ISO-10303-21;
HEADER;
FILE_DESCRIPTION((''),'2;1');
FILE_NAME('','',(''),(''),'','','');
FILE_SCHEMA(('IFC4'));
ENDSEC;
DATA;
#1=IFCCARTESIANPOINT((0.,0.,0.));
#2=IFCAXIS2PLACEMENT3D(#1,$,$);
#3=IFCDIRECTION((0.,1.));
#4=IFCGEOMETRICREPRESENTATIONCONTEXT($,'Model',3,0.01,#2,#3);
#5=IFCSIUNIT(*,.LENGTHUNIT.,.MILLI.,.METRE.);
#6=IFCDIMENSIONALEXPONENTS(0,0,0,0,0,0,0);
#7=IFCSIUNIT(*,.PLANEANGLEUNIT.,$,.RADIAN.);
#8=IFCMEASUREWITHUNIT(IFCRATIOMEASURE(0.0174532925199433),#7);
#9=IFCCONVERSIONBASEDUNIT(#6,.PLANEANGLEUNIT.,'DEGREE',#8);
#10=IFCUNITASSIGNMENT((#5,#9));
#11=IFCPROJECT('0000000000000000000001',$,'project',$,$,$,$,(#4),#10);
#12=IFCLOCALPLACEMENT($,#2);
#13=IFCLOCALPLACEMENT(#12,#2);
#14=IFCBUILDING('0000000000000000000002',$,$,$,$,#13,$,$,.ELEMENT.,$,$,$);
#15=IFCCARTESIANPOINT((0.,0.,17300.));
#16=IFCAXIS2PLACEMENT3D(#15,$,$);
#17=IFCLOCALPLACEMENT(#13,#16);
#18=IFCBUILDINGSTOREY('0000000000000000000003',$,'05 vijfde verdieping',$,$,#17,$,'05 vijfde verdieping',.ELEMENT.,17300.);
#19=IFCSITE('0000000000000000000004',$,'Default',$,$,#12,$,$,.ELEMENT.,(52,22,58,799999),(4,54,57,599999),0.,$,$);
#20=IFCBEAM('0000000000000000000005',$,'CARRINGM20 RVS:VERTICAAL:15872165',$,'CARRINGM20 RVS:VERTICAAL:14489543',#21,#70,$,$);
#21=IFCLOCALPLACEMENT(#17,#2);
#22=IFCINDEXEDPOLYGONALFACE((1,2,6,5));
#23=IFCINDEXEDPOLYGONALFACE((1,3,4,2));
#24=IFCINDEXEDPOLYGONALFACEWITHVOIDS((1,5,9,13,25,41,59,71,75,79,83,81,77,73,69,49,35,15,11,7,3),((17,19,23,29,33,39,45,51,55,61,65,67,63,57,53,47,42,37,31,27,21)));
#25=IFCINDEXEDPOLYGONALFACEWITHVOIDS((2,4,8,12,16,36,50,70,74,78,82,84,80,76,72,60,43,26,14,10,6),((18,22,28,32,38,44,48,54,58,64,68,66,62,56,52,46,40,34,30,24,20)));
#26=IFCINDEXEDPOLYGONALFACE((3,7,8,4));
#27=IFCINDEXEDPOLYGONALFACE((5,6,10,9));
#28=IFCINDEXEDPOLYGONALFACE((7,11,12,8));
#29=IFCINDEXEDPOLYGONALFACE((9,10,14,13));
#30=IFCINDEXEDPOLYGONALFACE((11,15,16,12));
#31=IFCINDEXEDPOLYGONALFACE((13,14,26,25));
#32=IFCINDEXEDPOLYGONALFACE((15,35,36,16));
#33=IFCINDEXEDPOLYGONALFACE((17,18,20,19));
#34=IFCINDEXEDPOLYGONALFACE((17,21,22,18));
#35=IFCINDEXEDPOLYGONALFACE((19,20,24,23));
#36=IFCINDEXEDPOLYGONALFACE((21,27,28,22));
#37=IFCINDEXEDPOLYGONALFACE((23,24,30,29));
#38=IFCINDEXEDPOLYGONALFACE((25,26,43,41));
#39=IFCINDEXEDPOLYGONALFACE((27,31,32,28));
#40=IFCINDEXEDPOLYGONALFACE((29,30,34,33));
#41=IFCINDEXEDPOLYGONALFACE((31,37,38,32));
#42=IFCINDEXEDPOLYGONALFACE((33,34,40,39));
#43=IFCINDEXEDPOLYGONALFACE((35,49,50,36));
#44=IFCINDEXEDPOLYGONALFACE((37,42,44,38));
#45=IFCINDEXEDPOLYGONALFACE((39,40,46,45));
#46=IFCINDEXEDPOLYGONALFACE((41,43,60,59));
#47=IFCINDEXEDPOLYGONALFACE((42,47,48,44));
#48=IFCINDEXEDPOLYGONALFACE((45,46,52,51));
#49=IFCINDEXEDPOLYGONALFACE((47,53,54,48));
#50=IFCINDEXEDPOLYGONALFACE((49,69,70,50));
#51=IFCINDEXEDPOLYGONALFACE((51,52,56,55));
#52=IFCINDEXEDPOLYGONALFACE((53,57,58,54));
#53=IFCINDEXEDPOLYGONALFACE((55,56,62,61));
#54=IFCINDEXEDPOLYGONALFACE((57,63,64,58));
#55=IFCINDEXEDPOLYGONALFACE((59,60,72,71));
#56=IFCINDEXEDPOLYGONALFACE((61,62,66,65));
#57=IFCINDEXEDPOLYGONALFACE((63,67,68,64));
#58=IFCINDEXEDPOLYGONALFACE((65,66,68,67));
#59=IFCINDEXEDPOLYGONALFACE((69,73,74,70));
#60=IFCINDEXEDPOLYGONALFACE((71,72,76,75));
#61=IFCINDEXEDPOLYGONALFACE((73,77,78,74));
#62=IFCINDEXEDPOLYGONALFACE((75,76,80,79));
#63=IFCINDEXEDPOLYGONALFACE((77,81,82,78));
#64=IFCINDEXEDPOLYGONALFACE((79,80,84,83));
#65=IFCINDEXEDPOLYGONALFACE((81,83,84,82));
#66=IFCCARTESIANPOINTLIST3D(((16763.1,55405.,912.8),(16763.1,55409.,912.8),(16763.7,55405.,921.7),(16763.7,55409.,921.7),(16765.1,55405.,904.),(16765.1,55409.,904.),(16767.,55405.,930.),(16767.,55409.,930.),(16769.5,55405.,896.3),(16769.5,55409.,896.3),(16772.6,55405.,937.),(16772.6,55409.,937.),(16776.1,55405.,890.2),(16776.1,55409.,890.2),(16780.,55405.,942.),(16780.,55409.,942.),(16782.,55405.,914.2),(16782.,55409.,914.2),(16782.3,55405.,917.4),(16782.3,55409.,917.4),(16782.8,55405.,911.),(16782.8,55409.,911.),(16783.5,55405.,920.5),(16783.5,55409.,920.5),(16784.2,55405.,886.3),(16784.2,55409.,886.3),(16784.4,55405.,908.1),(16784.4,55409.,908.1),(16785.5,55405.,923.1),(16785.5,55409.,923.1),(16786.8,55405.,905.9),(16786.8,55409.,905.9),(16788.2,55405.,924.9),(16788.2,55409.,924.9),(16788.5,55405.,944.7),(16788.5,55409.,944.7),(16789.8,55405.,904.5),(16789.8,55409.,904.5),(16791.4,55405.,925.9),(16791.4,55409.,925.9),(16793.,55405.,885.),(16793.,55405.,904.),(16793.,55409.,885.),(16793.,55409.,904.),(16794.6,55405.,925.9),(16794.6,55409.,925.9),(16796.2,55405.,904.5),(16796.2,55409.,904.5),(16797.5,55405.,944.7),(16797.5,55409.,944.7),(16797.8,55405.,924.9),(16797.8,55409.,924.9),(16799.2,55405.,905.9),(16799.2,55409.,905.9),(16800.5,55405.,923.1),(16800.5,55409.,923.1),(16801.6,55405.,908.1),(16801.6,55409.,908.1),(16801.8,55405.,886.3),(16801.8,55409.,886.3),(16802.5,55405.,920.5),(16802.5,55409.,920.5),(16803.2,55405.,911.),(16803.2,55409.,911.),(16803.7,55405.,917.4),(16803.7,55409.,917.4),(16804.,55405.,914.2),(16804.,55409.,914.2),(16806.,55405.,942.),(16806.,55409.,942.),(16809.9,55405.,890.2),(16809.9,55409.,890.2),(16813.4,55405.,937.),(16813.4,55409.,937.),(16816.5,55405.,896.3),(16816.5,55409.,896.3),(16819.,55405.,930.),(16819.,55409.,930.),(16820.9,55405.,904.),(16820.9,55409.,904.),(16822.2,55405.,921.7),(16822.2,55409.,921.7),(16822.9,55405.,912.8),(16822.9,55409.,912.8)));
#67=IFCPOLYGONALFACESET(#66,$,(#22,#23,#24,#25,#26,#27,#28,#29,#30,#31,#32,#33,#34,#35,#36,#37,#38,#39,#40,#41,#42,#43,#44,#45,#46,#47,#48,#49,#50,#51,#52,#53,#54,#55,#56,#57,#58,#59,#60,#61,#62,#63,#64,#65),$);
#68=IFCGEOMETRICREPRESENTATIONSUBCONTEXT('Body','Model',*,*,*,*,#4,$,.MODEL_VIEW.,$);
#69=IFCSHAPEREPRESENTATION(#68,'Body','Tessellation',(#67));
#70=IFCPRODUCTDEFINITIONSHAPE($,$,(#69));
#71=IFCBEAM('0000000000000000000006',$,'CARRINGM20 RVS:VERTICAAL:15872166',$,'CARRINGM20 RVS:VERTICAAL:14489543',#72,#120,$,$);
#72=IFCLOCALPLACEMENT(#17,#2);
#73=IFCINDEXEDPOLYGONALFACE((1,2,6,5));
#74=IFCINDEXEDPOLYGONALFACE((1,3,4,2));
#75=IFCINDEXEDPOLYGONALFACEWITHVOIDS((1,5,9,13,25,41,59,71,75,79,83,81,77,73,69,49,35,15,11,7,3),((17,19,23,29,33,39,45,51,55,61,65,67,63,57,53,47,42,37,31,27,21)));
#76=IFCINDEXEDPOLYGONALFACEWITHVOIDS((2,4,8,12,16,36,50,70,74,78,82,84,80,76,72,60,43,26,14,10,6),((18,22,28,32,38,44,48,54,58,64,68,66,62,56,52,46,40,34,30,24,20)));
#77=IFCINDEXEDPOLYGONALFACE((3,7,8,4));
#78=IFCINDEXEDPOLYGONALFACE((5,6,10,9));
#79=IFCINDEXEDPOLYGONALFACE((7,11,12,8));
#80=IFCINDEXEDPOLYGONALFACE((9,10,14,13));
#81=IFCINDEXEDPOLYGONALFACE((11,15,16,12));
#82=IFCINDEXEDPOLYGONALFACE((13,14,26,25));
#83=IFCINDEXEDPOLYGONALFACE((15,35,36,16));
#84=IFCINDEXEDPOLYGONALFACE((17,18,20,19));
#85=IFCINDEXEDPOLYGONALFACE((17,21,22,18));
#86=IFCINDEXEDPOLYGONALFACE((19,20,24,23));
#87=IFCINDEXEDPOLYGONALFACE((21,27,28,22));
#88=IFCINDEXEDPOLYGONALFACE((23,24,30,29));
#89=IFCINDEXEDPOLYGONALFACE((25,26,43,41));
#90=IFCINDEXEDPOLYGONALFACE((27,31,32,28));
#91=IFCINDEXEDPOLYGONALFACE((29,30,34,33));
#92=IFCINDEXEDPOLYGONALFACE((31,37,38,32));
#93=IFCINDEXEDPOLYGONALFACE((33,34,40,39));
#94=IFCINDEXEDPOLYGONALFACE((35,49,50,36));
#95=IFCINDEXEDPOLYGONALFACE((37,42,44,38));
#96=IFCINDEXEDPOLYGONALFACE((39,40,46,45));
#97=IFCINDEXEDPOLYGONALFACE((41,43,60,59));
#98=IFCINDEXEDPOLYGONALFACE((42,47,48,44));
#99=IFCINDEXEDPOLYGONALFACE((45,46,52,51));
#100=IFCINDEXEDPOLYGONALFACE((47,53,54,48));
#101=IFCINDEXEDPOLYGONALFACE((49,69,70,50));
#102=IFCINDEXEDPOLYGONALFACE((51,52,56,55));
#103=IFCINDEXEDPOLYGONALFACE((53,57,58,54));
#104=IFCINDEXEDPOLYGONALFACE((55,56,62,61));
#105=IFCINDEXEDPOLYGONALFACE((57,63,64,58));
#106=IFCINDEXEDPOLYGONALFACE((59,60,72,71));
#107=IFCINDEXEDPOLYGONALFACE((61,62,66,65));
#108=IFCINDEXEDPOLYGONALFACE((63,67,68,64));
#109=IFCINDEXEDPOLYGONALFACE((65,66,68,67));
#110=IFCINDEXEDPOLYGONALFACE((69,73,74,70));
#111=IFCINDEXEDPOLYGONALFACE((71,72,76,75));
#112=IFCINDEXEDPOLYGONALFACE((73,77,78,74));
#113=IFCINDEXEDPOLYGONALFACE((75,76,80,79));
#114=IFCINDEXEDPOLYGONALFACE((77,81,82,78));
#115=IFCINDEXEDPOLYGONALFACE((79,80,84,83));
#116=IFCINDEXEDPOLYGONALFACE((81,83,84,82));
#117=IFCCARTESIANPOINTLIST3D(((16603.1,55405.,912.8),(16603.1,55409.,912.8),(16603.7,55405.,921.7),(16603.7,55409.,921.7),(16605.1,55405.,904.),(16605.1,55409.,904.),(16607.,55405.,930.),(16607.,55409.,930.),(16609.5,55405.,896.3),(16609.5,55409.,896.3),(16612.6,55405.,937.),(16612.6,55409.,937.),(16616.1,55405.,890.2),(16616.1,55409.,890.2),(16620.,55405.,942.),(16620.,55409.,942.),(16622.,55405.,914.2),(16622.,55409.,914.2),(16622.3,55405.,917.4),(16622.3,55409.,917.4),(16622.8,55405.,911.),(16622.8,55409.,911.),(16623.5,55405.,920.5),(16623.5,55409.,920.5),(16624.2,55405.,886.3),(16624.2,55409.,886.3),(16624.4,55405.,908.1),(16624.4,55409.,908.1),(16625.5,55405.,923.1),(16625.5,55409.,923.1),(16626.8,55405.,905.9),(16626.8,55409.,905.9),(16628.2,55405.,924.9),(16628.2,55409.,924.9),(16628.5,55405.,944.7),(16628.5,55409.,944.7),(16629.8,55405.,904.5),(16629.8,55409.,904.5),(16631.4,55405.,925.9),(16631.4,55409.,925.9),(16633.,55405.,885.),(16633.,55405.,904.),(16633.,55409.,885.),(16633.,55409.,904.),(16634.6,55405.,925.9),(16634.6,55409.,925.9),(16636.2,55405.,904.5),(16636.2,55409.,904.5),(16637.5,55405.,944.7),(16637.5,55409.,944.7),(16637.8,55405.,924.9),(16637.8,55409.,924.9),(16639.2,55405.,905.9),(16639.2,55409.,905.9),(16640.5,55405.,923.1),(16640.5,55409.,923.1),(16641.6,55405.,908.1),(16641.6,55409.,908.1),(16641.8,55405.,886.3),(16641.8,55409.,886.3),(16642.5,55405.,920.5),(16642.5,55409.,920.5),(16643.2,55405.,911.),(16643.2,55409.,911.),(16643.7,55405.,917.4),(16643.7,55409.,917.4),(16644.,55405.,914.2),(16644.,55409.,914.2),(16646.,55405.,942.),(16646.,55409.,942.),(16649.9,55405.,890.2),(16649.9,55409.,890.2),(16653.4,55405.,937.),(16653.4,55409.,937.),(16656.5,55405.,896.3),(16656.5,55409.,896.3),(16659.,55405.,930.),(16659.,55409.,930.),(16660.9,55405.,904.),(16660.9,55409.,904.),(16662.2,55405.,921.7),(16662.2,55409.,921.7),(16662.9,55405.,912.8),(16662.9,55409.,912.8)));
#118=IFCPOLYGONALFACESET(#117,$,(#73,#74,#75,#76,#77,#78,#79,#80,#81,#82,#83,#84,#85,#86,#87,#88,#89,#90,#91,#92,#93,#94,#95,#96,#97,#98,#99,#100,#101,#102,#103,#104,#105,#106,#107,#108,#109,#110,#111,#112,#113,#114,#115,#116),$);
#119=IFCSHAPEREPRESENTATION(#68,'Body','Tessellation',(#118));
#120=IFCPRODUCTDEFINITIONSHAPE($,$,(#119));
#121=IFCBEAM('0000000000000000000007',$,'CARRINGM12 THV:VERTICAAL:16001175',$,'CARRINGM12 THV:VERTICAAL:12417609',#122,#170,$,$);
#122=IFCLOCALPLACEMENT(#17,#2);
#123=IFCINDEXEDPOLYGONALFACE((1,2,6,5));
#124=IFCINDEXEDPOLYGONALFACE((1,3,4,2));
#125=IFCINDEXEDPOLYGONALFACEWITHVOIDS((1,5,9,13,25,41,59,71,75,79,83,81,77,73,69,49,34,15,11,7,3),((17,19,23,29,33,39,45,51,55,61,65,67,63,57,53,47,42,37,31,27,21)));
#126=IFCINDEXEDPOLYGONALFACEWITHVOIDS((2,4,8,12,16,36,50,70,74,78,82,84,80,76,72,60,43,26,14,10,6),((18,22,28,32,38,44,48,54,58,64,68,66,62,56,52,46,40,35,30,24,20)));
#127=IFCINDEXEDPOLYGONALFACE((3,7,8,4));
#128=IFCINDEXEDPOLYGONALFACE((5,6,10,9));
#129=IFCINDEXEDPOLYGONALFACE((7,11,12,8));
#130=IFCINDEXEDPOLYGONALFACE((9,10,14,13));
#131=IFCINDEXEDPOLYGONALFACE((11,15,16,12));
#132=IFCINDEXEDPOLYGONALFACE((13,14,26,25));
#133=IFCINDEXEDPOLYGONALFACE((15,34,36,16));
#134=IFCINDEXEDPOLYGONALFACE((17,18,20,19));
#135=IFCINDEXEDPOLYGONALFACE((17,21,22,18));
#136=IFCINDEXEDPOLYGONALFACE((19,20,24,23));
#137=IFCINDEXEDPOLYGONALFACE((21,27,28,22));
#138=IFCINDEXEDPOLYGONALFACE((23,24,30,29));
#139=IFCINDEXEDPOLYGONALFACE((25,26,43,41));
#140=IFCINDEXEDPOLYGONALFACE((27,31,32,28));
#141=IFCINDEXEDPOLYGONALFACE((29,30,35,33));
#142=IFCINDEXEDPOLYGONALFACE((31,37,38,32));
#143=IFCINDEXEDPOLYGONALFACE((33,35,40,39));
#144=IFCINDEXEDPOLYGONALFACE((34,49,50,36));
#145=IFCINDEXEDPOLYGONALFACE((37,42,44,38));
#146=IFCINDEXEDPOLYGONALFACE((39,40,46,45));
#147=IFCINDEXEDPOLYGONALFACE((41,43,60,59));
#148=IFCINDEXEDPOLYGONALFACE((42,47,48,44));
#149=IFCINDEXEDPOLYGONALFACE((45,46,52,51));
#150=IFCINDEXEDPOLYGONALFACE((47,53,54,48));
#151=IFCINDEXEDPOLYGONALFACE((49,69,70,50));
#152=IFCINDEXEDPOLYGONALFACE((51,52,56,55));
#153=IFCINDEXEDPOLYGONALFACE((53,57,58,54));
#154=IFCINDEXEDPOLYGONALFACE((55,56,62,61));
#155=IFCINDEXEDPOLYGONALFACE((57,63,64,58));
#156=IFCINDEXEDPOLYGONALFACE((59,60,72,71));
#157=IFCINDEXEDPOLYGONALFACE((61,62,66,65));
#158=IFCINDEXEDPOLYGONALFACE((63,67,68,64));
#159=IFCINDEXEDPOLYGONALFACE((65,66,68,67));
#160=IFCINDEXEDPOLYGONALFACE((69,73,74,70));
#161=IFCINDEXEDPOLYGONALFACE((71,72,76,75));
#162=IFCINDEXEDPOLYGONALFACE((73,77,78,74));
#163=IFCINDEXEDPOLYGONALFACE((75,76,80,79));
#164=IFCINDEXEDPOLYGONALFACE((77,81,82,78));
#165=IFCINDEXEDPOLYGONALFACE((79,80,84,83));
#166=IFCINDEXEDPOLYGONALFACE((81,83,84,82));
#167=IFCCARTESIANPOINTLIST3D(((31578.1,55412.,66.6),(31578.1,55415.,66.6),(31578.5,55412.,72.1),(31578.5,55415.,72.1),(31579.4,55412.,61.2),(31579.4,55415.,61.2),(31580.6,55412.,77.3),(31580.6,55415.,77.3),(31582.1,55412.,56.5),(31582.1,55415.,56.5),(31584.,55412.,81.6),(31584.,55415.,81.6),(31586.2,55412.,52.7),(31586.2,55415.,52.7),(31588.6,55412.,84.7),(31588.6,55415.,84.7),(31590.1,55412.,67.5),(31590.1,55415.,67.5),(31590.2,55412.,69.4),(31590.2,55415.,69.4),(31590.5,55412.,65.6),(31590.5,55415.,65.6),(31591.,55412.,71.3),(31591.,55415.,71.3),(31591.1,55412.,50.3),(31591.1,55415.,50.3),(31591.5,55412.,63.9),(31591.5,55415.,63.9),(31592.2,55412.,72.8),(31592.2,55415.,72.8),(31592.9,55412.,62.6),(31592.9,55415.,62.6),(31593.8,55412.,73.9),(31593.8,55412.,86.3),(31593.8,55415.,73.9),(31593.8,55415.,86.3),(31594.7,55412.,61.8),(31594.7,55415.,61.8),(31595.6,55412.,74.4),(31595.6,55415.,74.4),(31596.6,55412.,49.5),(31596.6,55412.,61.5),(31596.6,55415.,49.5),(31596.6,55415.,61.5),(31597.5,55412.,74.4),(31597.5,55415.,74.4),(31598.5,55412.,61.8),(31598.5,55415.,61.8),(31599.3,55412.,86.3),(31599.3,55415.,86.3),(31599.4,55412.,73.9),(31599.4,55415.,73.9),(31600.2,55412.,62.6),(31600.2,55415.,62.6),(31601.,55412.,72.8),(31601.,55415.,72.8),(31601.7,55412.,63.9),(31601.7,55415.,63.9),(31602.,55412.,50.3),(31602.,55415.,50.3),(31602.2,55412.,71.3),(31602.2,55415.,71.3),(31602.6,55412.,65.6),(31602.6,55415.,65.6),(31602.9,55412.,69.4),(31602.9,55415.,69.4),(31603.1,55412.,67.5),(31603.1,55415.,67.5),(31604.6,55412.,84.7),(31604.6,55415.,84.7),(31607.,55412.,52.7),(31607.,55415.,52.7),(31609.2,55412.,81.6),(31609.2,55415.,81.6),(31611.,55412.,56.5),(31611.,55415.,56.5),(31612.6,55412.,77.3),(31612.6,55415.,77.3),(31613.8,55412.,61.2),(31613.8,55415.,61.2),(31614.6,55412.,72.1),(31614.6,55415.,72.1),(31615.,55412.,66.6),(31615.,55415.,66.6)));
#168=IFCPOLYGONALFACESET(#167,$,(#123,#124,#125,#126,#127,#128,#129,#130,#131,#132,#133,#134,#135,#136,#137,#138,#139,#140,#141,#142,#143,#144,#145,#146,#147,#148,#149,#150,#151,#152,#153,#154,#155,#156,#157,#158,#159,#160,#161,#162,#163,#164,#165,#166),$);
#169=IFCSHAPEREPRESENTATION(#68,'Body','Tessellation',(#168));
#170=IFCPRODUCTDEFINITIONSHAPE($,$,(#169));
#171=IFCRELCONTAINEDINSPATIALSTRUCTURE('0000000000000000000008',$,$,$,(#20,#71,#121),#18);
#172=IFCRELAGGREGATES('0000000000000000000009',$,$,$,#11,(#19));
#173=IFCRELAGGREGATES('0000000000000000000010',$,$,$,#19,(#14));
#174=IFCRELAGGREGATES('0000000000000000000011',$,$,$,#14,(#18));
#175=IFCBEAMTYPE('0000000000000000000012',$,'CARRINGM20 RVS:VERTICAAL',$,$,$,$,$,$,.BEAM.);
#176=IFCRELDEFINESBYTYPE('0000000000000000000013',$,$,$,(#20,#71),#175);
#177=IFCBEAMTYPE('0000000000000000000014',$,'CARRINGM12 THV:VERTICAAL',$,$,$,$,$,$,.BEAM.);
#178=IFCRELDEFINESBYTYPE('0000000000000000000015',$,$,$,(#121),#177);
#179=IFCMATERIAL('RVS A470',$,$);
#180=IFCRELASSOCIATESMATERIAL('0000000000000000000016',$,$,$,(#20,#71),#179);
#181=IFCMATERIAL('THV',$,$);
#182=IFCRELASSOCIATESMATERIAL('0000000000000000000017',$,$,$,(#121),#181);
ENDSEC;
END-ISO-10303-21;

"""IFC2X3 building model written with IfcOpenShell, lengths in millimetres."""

from ifc_helpers import new_model, entity, si_unit, converted_unit, direction, frame, origin, origin_2d_with_axis, place, context, subcontext, project, spatial, hollow_circle, extrude, material, type_object, element, save


model = new_model("IFC2X3")

# Units and contexts
model_context = context("Model", 3, precision=0.01, world=origin(), true_north=direction((0.0, 1.0)))
body_context = subcontext(model_context, "Body", "Model", "MODEL_VIEW")
ifc_project = project(units=[si_unit("LENGTHUNIT", "METRE", prefix="MILLI"), converted_unit("PLANEANGLEUNIT", "DEGREE", entity("IfcRatioMeasure", 0.0174532925199433), si_unit("PLANEANGLEUNIT", "RADIAN"), dimensions=[0, 0, 0, 0, 0, 0, 0])], contexts=[model_context])

# Site, building, storey
site_placement = place(None, origin())
site = spatial("IfcSite", under=ifc_project, at=site_placement, Name="Default", CompositionType="ELEMENT", RefLatitude=(52, 22, 58, 799999), RefLongitude=(4, 54, 57, 599999), RefElevation=0.0)
building_placement = place(site_placement, origin())
building = spatial("IfcBuilding", under=site, at=building_placement, CompositionType="ELEMENT")
storey_placement = place(building_placement, frame((0.0, 0.0, 17300.0)))
storey = spatial("IfcBuildingStorey", under=building, at=storey_placement, Name="05 vijfde verdieping", LongName="05 vijfde verdieping", CompositionType="ELEMENT", Elevation=17300.0)

# Beams
ifc_material_1 = material(Name="RVS A470")
beam_type_1 = type_object("IfcBeamType", Name="CARRINGM20 RVS:VERTICAAL", PredefinedType="BEAM")
beam_1_placement = place(storey_placement, origin())
element("IfcBeam", 1, at=beam_1_placement, inside=storey, type_object=beam_type_1, material=ifc_material_1, Name="CARRINGM20 RVS:VERTICAAL:15872165", ObjectType="CARRINGM20 RVS:VERTICAAL:14489543", context=body_context, shape_type="SweptSolid", body=[
    extrude(hollow_circle(Radius=30.0, WallThickness=19.0, at=origin_2d_with_axis()), frame((16793.0, 55405.0, 915.0), z_axis=(0.0, 1.0, 0.0), x_axis=(0.0, 0.0, -1.0)), (0.0, 0.0, 1.0), 4.0),
])
beam_2_placement = place(storey_placement, origin())
element("IfcBeam", 2, at=beam_2_placement, inside=storey, type_object=beam_type_1, material=ifc_material_1, Name="CARRINGM20 RVS:VERTICAAL:15872166", ObjectType="CARRINGM20 RVS:VERTICAAL:14489543", context=body_context, shape_type="SweptSolid", body=[
    extrude(hollow_circle(Radius=30.0, WallThickness=19.0, at=origin_2d_with_axis()), frame((16633.0, 55405.0, 915.0), z_axis=(0.0, 1.0, 0.0), x_axis=(0.0, 0.0, -1.0)), (0.0, 0.0, 1.0), 4.0),
])
ifc_material_2 = material(Name="THV")
beam_type_2 = type_object("IfcBeamType", Name="CARRINGM12 THV:VERTICAAL", PredefinedType="BEAM")
beam_3_placement = place(storey_placement, origin())
element("IfcBeam", 3, at=beam_3_placement, inside=storey, type_object=beam_type_2, material=ifc_material_2, Name="CARRINGM12 THV:VERTICAAL:16001175", ObjectType="CARRINGM12 THV:VERTICAAL:12417609", context=body_context, shape_type="SweptSolid", body=[
    extrude(hollow_circle(Radius=18.5, WallThickness=12.0, at=origin_2d_with_axis()), frame((31596.6, 55412.0, 68.0), z_axis=(0.0, 1.0, 0.0), x_axis=(0.0, 0.0, -1.0)), (0.0, 0.0, 1.0), 3.0),
])

save(model, "model.ifc")
